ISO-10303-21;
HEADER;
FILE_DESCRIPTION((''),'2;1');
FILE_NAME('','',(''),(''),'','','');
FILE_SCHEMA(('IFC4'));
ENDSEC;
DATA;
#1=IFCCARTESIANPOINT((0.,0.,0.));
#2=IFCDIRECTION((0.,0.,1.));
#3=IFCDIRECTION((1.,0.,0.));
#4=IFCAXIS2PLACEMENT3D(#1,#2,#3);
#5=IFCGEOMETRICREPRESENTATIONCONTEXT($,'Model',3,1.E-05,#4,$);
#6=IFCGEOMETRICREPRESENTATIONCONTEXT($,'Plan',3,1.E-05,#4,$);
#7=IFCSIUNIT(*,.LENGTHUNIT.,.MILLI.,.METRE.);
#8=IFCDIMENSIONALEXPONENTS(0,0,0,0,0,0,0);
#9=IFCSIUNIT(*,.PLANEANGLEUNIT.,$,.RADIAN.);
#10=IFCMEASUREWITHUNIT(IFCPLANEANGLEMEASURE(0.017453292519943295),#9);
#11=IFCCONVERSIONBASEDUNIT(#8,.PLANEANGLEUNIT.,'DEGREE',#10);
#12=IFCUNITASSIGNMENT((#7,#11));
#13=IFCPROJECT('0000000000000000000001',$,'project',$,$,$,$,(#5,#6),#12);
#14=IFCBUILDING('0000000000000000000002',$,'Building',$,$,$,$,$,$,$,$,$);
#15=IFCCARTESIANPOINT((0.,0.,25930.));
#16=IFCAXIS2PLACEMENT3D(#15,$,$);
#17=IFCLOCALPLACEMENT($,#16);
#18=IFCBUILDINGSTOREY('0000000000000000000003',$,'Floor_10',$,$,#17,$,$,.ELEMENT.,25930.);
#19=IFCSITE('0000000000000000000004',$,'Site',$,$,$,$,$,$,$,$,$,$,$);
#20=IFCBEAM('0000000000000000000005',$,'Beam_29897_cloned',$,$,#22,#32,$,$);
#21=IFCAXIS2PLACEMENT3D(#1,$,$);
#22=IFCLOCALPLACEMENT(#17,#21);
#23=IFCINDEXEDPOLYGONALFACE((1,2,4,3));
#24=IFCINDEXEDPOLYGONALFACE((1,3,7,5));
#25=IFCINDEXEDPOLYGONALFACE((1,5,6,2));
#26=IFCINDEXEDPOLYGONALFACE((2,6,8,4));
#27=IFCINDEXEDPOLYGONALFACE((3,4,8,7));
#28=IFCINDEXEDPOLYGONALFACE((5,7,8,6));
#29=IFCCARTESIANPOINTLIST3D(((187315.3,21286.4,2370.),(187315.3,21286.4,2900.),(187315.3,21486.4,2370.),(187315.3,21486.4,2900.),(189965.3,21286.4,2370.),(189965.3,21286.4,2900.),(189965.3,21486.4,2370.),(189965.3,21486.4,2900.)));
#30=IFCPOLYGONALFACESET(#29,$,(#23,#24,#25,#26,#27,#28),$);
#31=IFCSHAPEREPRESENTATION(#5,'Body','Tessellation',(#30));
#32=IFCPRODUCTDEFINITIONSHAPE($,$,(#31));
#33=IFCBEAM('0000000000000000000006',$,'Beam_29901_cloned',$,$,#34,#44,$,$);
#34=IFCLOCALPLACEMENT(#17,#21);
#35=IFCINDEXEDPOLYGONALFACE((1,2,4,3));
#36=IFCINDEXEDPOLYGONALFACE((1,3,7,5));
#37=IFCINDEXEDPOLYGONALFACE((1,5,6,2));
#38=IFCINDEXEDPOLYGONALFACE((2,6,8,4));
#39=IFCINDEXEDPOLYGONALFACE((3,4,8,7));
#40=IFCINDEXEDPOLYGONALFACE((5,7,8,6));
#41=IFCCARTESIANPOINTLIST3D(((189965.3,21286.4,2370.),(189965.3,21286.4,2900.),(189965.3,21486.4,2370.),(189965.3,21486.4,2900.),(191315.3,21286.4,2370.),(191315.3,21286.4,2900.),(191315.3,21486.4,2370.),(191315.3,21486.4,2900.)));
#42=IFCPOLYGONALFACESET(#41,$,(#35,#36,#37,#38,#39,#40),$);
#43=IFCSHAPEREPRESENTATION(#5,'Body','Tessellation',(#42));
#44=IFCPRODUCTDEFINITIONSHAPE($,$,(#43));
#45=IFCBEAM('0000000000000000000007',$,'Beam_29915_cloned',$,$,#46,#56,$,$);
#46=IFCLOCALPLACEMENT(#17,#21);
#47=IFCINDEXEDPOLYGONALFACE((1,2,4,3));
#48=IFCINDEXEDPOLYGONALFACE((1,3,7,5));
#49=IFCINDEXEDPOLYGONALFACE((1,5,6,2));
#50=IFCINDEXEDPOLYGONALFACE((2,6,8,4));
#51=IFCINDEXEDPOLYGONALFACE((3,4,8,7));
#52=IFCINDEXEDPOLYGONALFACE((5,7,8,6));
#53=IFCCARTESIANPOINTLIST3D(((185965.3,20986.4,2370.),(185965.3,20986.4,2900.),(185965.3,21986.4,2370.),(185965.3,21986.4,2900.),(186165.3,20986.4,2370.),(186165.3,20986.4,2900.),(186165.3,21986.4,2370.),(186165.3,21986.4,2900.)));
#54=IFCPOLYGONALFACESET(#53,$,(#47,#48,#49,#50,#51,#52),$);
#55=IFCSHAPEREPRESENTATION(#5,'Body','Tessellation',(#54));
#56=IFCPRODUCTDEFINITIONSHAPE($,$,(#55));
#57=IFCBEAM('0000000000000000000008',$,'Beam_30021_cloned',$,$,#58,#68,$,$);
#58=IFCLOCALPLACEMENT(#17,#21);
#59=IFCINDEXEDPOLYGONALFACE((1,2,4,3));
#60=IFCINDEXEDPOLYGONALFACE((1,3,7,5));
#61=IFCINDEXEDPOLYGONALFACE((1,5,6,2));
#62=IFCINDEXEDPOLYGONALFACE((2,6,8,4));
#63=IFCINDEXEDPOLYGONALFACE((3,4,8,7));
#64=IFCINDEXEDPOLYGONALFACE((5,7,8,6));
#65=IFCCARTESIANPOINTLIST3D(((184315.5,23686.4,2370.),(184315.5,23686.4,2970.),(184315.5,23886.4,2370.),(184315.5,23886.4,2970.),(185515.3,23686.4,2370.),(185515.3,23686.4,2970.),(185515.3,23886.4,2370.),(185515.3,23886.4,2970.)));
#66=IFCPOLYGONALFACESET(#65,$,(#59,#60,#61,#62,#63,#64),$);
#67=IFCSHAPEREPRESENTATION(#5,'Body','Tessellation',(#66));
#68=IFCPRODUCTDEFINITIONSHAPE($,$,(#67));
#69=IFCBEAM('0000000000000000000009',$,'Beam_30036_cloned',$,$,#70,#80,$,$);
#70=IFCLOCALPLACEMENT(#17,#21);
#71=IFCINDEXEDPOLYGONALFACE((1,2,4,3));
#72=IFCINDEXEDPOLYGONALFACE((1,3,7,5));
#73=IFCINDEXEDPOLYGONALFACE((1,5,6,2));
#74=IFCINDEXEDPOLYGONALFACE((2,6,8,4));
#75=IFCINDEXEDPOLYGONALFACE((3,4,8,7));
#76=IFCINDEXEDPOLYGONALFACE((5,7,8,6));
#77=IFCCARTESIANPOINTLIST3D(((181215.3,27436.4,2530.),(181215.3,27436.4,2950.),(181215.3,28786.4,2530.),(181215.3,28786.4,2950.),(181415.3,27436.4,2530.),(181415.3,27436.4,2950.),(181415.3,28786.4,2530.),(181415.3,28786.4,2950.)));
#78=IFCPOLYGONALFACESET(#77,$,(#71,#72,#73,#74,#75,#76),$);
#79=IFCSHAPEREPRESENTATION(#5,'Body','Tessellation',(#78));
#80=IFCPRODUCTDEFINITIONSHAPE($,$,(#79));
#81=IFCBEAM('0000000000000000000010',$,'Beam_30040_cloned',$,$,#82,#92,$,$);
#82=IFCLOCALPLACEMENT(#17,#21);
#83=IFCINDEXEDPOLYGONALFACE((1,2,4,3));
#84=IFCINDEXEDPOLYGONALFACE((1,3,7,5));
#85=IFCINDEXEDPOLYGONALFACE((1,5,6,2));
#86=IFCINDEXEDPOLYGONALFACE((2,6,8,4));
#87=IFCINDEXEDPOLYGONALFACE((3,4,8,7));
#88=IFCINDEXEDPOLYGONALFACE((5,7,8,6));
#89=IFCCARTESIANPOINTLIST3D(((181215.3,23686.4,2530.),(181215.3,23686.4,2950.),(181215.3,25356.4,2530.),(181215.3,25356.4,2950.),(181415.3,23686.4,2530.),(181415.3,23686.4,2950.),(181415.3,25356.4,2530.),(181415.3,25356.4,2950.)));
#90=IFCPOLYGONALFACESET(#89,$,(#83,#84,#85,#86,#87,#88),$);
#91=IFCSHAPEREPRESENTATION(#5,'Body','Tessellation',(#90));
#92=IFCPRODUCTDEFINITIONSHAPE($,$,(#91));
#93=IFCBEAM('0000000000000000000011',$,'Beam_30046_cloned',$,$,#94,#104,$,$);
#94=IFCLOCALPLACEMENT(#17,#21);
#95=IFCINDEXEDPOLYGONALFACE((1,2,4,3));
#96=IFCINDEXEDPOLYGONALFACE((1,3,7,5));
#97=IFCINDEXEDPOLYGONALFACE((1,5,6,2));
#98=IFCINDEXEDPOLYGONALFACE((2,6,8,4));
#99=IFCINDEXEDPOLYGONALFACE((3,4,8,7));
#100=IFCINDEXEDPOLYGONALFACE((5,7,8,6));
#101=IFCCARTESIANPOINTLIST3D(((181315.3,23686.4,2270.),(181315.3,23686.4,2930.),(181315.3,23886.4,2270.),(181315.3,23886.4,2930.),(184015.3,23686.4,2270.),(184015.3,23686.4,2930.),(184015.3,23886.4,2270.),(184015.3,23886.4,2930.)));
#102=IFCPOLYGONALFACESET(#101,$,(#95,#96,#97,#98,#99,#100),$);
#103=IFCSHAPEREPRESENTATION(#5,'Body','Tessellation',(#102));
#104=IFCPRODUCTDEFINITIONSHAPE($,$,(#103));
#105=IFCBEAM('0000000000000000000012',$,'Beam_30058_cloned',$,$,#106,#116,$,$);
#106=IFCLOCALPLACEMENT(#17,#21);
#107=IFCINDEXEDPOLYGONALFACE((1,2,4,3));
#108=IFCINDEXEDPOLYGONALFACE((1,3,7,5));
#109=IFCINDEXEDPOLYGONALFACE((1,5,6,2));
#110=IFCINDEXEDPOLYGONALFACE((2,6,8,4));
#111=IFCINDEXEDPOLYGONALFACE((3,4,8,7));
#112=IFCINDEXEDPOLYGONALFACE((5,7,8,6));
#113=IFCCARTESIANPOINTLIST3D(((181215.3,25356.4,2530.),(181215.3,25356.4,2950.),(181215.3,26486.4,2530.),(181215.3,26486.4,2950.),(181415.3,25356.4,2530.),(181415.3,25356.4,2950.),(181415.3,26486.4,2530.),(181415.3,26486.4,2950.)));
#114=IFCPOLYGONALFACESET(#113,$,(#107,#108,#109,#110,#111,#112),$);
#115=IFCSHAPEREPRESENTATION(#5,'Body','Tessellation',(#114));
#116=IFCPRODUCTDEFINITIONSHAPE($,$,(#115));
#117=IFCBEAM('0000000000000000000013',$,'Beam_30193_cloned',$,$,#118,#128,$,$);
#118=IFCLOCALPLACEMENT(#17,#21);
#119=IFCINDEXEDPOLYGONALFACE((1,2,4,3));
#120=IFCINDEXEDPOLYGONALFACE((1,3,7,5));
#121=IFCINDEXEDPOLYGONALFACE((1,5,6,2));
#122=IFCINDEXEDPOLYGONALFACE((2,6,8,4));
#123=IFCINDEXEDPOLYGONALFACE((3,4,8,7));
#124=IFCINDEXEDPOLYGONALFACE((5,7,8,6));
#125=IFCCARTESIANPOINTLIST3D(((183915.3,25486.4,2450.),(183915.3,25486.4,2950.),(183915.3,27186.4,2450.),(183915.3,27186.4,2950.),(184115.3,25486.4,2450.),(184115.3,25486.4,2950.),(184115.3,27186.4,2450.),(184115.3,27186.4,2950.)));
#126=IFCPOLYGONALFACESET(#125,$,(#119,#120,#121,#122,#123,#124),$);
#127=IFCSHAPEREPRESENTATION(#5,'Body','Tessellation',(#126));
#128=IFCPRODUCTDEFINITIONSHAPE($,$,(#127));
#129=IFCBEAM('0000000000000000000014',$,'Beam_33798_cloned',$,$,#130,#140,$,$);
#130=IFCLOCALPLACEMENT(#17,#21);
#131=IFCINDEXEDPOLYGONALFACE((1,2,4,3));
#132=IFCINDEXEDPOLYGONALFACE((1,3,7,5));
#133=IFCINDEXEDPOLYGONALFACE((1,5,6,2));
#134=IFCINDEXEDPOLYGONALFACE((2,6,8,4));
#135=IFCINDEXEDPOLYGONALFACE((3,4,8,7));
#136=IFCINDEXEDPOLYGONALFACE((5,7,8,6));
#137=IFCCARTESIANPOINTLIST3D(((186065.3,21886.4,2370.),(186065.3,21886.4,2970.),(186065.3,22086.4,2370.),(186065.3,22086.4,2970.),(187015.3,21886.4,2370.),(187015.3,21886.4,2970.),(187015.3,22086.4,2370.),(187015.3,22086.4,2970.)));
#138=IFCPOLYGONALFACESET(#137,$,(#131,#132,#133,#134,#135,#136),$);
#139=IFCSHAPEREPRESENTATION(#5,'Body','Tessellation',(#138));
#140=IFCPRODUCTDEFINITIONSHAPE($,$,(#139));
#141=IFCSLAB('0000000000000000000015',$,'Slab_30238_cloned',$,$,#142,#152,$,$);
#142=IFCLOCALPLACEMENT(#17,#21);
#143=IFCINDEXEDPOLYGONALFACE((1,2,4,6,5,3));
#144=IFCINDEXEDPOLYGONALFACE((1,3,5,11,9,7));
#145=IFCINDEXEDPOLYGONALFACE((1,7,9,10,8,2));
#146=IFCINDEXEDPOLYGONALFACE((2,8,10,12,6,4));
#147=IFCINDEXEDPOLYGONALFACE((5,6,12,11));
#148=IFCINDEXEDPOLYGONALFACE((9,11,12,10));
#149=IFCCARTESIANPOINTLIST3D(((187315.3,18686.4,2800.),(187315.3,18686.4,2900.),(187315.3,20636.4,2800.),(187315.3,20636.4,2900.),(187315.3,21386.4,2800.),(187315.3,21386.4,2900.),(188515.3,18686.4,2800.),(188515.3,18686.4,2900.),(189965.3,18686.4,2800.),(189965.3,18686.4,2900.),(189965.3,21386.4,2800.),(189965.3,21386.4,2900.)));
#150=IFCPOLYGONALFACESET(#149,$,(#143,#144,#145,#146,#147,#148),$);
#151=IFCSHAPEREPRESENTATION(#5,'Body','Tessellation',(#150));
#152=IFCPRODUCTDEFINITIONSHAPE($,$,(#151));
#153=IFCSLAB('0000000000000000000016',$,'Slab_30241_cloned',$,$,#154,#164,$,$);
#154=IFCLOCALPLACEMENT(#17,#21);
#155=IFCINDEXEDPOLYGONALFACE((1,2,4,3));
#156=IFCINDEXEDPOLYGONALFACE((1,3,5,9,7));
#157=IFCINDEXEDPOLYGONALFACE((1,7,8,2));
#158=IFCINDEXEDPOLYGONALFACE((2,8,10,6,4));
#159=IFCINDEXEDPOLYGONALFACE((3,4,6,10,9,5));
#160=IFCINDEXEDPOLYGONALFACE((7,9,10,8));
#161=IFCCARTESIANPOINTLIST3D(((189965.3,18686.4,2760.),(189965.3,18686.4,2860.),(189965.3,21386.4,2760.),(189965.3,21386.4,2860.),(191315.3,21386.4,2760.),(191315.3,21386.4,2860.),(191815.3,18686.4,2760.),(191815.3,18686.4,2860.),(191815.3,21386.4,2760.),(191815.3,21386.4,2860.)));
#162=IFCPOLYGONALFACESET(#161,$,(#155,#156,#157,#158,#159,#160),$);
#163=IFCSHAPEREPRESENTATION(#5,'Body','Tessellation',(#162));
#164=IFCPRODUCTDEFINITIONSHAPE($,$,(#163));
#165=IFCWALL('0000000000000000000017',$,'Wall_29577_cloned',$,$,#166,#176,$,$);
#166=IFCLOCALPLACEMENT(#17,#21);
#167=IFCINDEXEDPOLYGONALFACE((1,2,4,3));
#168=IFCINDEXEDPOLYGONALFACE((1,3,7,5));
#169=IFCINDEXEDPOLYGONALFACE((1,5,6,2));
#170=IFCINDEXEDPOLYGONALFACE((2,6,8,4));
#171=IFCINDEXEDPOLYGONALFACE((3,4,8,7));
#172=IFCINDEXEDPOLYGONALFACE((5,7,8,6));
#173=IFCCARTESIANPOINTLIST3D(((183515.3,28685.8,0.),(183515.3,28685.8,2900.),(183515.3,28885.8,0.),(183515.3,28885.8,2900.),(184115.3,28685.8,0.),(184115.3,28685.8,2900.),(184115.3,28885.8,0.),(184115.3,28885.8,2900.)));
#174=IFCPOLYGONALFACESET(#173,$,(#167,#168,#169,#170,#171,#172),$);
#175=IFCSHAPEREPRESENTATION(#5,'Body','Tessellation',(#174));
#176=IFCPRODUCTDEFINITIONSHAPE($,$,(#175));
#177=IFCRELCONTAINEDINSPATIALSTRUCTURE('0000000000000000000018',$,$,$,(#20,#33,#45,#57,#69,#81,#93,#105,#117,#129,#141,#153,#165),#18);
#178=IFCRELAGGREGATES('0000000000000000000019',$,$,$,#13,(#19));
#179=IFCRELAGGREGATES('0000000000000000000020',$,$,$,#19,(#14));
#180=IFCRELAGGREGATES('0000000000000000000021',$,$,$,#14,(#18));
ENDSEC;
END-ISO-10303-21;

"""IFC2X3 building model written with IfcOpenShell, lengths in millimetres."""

from ifc_helpers import new_model, entity, si_unit, converted_unit, frame, origin_with_axes, origin_2d, place, context, project, spatial, polyline, rectangle, outline, extrude, source, transform, mapped, element, save


model = new_model("IFC2X3")

# Units and contexts
model_context = context("Model", 3, precision=1e-05, world=origin_with_axes())
plan_context = context("Plan", 3, precision=1e-05, world=origin_with_axes())
ifc_project = project(units=[si_unit("LENGTHUNIT", "METRE", prefix="MILLI"), converted_unit("PLANEANGLEUNIT", "DEGREE", entity("IfcPlaneAngleMeasure", 0.017453292519943295), si_unit("PLANEANGLEUNIT", "RADIAN"), dimensions=[0, 0, 0, 0, 0, 0, 0])], contexts=[model_context, plan_context])

# Site, building, storey
site = spatial("IfcSite", under=ifc_project, Name="Site")
building = spatial("IfcBuilding", under=site, Name="Building")
storey_placement = place(None, frame((0.0, 0.0, 25930.0)))
storey = spatial("IfcBuildingStorey", under=building, at=storey_placement, Name="Floor_10", CompositionType="ELEMENT", Elevation=25930.0)

# Beams
shared_shape_1 = source(origin_with_axes(), model_context, "Body", "SweptSolid", [
    extrude(rectangle(XDim=200.0, YDim=530.0, at=origin_2d()), origin_with_axes(), (0.0, 0.0, 1.0), 2650.0),
])
beam_1_placement = place(storey_placement, frame((187315.3, 21386.4, 2635.0), z_axis=(2650.0, 0.0, 0.0), x_axis=(0.0, -2650.0, 0.0)))
element("IfcBeam", 1, at=beam_1_placement, inside=storey, Name="Beam_29897_cloned", context=model_context, shape_type="MappedRepresentation", body=[
    mapped(shared_shape_1, transform((0.0, 0.0, 0.0), x_axis=(1.0, 0.0, 0.0), y_axis=(0.0, 1.0, 0.0), z_axis=(0.0, 0.0, 1.0), scale=1.0)),
])
shared_shape_2 = source(origin_with_axes(), model_context, "Body", "SweptSolid", [
    extrude(rectangle(XDim=200.0, YDim=530.0, at=origin_2d()), origin_with_axes(), (0.0, 0.0, 1.0), 1350.0),
])
beam_2_placement = place(storey_placement, frame((189965.3, 21386.4, 2635.0), z_axis=(1350.0, 0.0, 0.0), x_axis=(0.0, -1350.0, 0.0)))
element("IfcBeam", 2, at=beam_2_placement, inside=storey, Name="Beam_29901_cloned", context=model_context, shape_type="MappedRepresentation", body=[
    mapped(shared_shape_2, transform((0.0, 0.0, 0.0), x_axis=(1.0, 0.0, 0.0), y_axis=(0.0, 1.0, 0.0), z_axis=(0.0, 0.0, 1.0), scale=1.0)),
])
shared_shape_3 = source(origin_with_axes(), model_context, "Body", "SweptSolid", [
    extrude(rectangle(XDim=200.0, YDim=530.0, at=origin_2d()), origin_with_axes(), (0.0, 0.0, 1.0), 1000.0),
])
beam_3_placement = place(storey_placement, frame((186065.3, 20986.4, 2635.0), z_axis=(0.0, 1000.0, 0.0), x_axis=(1000.0, 0.0, 0.0)))
element("IfcBeam", 3, at=beam_3_placement, inside=storey, Name="Beam_29915_cloned", context=model_context, shape_type="MappedRepresentation", body=[
    mapped(shared_shape_3, transform((0.0, 0.0, 0.0), x_axis=(1.0, 0.0, 0.0), y_axis=(0.0, 1.0, 0.0), z_axis=(0.0, 0.0, 1.0), scale=1.0)),
])
shared_shape_4 = source(origin_with_axes(), model_context, "Body", "SweptSolid", [
    extrude(rectangle(XDim=200.0, YDim=600.0, at=origin_2d()), origin_with_axes(), (0.0, 0.0, 1.0), 1199.9),
])
beam_4_placement = place(storey_placement, frame((184315.5, 23786.4, 2670.0), z_axis=(1199.853373, 0.000009, 0.0), x_axis=(0.000009, -1199.853373, 0.0)))
element("IfcBeam", 4, at=beam_4_placement, inside=storey, Name="Beam_30021_cloned", context=model_context, shape_type="MappedRepresentation", body=[
    mapped(shared_shape_4, transform((0.0, 0.0, 0.0), x_axis=(1.0, 0.0, 0.0), y_axis=(0.0, 1.0, 0.0), z_axis=(0.0, 0.0, 1.0), scale=1.0)),
])
shared_shape_5 = source(origin_with_axes(), model_context, "Body", "SweptSolid", [
    extrude(rectangle(XDim=200.0, YDim=420.0, at=origin_2d()), origin_with_axes(), (0.0, 0.0, 1.0), 1350.0),
])
beam_5_placement = place(storey_placement, frame((181315.3, 27436.4, 2740.0), z_axis=(0.0, 1350.0, 0.0), x_axis=(1350.0, 0.0, 0.0)))
element("IfcBeam", 5, at=beam_5_placement, inside=storey, Name="Beam_30036_cloned", context=model_context, shape_type="MappedRepresentation", body=[
    mapped(shared_shape_5, transform((0.0, 0.0, 0.0), x_axis=(1.0, 0.0, 0.0), y_axis=(0.0, 1.0, 0.0), z_axis=(0.0, 0.0, 1.0), scale=1.0)),
])
shared_shape_6 = source(origin_with_axes(), model_context, "Body", "SweptSolid", [
    extrude(rectangle(XDim=200.0, YDim=420.0, at=origin_2d()), origin_with_axes(), (0.0, 0.0, 1.0), 1670.0),
])
beam_6_placement = place(storey_placement, frame((181315.3, 23686.4, 2740.0), z_axis=(0.0, 1669.999995, 0.0), x_axis=(1669.999995, 0.0, 0.0)))
element("IfcBeam", 6, at=beam_6_placement, inside=storey, Name="Beam_30040_cloned", context=model_context, shape_type="MappedRepresentation", body=[
    mapped(shared_shape_6, transform((0.0, 0.0, 0.0), x_axis=(1.0, 0.0, 0.0), y_axis=(0.0, 1.0, 0.0), z_axis=(0.0, 0.0, 1.0), scale=1.0)),
])
shared_shape_7 = source(origin_with_axes(), model_context, "Body", "SweptSolid", [
    extrude(rectangle(XDim=200.0, YDim=660.0, at=origin_2d()), origin_with_axes(), (0.0, 0.0, 1.0), 2700.0),
])
beam_7_placement = place(storey_placement, frame((181315.3, 23786.4, 2600.0), z_axis=(2700.0, -0.000001, 0.0), x_axis=(-0.000001, -2700.0, 0.0)))
element("IfcBeam", 7, at=beam_7_placement, inside=storey, Name="Beam_30046_cloned", context=model_context, shape_type="MappedRepresentation", body=[
    mapped(shared_shape_7, transform((0.0, 0.0, 0.0), x_axis=(1.0, 0.0, 0.0), y_axis=(0.0, 1.0, 0.0), z_axis=(0.0, 0.0, 1.0), scale=1.0)),
])
shared_shape_8 = source(origin_with_axes(), model_context, "Body", "SweptSolid", [
    extrude(rectangle(XDim=200.0, YDim=420.0, at=origin_2d()), origin_with_axes(), (0.0, 0.0, 1.0), 1130.0),
])
beam_8_placement = place(storey_placement, frame((181315.3, 25356.4, 2740.0), z_axis=(0.0, 1130.0, 0.0), x_axis=(1130.0, 0.0, 0.0)))
element("IfcBeam", 8, at=beam_8_placement, inside=storey, Name="Beam_30058_cloned", context=model_context, shape_type="MappedRepresentation", body=[
    mapped(shared_shape_8, transform((0.0, 0.0, 0.0), x_axis=(1.0, 0.0, 0.0), y_axis=(0.0, 1.0, 0.0), z_axis=(0.0, 0.0, 1.0), scale=1.0)),
])
shared_shape_9 = source(origin_with_axes(), model_context, "Body", "SweptSolid", [
    extrude(rectangle(XDim=200.0, YDim=500.0, at=origin_2d()), origin_with_axes(), (0.0, 0.0, 1.0), 1700.0),
])
beam_9_placement = place(storey_placement, frame((184015.3, 25486.4, 2700.0), z_axis=(0.0, 1700.000002, 0.0), x_axis=(1700.000002, 0.0, 0.0)))
element("IfcBeam", 9, at=beam_9_placement, inside=storey, Name="Beam_30193_cloned", context=model_context, shape_type="MappedRepresentation", body=[
    mapped(shared_shape_9, transform((0.0, 0.0, 0.0), x_axis=(1.0, 0.0, 0.0), y_axis=(0.0, 1.0, 0.0), z_axis=(0.0, 0.0, 1.0), scale=1.0)),
])
shared_shape_10 = source(origin_with_axes(), model_context, "Body", "SweptSolid", [
    extrude(rectangle(XDim=200.0, YDim=600.0, at=origin_2d()), origin_with_axes(), (0.0, 0.0, 1.0), 950.0),
])
beam_10_placement = place(storey_placement, frame((186065.3, 21986.4, 2670.0), z_axis=(950.0, 0.0, 0.0), x_axis=(0.0, -950.0, 0.0)))
element("IfcBeam", 10, at=beam_10_placement, inside=storey, Name="Beam_33798_cloned", context=model_context, shape_type="MappedRepresentation", body=[
    mapped(shared_shape_10, transform((0.0, 0.0, 0.0), x_axis=(1.0, 0.0, 0.0), y_axis=(0.0, 1.0, 0.0), z_axis=(0.0, 0.0, 1.0), scale=1.0)),
])

# Slabs
shared_shape_11 = source(origin_with_axes(), model_context, "Body", "SweptSolid", [
    extrude(outline(polyline([(0.0, 0.0), (750.0, 0.0), (2700.0, 0.0), (2700.0, 1200.0), (2700.0, 2650.0), (0.0, 2650.0)])), origin_with_axes(), (0.0, 0.0, 1.0), 100.0),
])
slab_1_placement = place(storey_placement, frame((187315.3, 21386.4, 2800.0), z_axis=(0.0, 0.0, 1.0), x_axis=(0.0, -750.0, 0.0)))
element("IfcSlab", 11, at=slab_1_placement, inside=storey, Name="Slab_30238_cloned", context=model_context, shape_type="MappedRepresentation", body=[
    mapped(shared_shape_11, transform((0.0, 0.0, 0.0), x_axis=(1.0, 0.0, 0.0), y_axis=(0.0, 1.0, 0.0), z_axis=(0.0, 0.0, 1.0), scale=1.0)),
])
shared_shape_12 = source(origin_with_axes(), model_context, "Body", "SweptSolid", [
    extrude(outline(polyline([(0.0, 0.0), (2700.0, 0.0), (2700.0, 1850.0), (0.0, 1850.0), (0.0, 1350.0)])), origin_with_axes(), (0.0, 0.0, 1.0), 100.0),
])
slab_2_placement = place(storey_placement, frame((189965.3, 21386.4, 2760.0), z_axis=(0.0, 0.0, 1.0), x_axis=(0.0, -2700.0, 0.0)))
element("IfcSlab", 12, at=slab_2_placement, inside=storey, Name="Slab_30241_cloned", context=model_context, shape_type="MappedRepresentation", body=[
    mapped(shared_shape_12, transform((0.0, 0.0, 0.0), x_axis=(1.0, 0.0, 0.0), y_axis=(0.0, 1.0, 0.0), z_axis=(0.0, 0.0, 1.0), scale=1.0)),
])

# Wall
shared_shape_13 = source(origin_with_axes(), model_context, "Body", "SweptSolid", [
    extrude(rectangle(XDim=600.0, YDim=200.0, at=origin_2d()), origin_with_axes(), (0.0, 0.0, 1.0), 2900.0),
])
wall_1_placement = place(storey_placement, frame((183815.3, 28785.8, 0.0), z_axis=(0.0, 0.0, 1.0), x_axis=(600.0, 0.0, 0.0)))
element("IfcWall", 13, at=wall_1_placement, inside=storey, Name="Wall_29577_cloned", context=model_context, shape_type="MappedRepresentation", body=[
    mapped(shared_shape_13, transform((0.0, 0.0, 0.0), x_axis=(1.0, 0.0, 0.0), y_axis=(0.0, 1.0, 0.0), z_axis=(0.0, 0.0, 1.0), scale=1.0)),
])

save(model, "model.ifc")
